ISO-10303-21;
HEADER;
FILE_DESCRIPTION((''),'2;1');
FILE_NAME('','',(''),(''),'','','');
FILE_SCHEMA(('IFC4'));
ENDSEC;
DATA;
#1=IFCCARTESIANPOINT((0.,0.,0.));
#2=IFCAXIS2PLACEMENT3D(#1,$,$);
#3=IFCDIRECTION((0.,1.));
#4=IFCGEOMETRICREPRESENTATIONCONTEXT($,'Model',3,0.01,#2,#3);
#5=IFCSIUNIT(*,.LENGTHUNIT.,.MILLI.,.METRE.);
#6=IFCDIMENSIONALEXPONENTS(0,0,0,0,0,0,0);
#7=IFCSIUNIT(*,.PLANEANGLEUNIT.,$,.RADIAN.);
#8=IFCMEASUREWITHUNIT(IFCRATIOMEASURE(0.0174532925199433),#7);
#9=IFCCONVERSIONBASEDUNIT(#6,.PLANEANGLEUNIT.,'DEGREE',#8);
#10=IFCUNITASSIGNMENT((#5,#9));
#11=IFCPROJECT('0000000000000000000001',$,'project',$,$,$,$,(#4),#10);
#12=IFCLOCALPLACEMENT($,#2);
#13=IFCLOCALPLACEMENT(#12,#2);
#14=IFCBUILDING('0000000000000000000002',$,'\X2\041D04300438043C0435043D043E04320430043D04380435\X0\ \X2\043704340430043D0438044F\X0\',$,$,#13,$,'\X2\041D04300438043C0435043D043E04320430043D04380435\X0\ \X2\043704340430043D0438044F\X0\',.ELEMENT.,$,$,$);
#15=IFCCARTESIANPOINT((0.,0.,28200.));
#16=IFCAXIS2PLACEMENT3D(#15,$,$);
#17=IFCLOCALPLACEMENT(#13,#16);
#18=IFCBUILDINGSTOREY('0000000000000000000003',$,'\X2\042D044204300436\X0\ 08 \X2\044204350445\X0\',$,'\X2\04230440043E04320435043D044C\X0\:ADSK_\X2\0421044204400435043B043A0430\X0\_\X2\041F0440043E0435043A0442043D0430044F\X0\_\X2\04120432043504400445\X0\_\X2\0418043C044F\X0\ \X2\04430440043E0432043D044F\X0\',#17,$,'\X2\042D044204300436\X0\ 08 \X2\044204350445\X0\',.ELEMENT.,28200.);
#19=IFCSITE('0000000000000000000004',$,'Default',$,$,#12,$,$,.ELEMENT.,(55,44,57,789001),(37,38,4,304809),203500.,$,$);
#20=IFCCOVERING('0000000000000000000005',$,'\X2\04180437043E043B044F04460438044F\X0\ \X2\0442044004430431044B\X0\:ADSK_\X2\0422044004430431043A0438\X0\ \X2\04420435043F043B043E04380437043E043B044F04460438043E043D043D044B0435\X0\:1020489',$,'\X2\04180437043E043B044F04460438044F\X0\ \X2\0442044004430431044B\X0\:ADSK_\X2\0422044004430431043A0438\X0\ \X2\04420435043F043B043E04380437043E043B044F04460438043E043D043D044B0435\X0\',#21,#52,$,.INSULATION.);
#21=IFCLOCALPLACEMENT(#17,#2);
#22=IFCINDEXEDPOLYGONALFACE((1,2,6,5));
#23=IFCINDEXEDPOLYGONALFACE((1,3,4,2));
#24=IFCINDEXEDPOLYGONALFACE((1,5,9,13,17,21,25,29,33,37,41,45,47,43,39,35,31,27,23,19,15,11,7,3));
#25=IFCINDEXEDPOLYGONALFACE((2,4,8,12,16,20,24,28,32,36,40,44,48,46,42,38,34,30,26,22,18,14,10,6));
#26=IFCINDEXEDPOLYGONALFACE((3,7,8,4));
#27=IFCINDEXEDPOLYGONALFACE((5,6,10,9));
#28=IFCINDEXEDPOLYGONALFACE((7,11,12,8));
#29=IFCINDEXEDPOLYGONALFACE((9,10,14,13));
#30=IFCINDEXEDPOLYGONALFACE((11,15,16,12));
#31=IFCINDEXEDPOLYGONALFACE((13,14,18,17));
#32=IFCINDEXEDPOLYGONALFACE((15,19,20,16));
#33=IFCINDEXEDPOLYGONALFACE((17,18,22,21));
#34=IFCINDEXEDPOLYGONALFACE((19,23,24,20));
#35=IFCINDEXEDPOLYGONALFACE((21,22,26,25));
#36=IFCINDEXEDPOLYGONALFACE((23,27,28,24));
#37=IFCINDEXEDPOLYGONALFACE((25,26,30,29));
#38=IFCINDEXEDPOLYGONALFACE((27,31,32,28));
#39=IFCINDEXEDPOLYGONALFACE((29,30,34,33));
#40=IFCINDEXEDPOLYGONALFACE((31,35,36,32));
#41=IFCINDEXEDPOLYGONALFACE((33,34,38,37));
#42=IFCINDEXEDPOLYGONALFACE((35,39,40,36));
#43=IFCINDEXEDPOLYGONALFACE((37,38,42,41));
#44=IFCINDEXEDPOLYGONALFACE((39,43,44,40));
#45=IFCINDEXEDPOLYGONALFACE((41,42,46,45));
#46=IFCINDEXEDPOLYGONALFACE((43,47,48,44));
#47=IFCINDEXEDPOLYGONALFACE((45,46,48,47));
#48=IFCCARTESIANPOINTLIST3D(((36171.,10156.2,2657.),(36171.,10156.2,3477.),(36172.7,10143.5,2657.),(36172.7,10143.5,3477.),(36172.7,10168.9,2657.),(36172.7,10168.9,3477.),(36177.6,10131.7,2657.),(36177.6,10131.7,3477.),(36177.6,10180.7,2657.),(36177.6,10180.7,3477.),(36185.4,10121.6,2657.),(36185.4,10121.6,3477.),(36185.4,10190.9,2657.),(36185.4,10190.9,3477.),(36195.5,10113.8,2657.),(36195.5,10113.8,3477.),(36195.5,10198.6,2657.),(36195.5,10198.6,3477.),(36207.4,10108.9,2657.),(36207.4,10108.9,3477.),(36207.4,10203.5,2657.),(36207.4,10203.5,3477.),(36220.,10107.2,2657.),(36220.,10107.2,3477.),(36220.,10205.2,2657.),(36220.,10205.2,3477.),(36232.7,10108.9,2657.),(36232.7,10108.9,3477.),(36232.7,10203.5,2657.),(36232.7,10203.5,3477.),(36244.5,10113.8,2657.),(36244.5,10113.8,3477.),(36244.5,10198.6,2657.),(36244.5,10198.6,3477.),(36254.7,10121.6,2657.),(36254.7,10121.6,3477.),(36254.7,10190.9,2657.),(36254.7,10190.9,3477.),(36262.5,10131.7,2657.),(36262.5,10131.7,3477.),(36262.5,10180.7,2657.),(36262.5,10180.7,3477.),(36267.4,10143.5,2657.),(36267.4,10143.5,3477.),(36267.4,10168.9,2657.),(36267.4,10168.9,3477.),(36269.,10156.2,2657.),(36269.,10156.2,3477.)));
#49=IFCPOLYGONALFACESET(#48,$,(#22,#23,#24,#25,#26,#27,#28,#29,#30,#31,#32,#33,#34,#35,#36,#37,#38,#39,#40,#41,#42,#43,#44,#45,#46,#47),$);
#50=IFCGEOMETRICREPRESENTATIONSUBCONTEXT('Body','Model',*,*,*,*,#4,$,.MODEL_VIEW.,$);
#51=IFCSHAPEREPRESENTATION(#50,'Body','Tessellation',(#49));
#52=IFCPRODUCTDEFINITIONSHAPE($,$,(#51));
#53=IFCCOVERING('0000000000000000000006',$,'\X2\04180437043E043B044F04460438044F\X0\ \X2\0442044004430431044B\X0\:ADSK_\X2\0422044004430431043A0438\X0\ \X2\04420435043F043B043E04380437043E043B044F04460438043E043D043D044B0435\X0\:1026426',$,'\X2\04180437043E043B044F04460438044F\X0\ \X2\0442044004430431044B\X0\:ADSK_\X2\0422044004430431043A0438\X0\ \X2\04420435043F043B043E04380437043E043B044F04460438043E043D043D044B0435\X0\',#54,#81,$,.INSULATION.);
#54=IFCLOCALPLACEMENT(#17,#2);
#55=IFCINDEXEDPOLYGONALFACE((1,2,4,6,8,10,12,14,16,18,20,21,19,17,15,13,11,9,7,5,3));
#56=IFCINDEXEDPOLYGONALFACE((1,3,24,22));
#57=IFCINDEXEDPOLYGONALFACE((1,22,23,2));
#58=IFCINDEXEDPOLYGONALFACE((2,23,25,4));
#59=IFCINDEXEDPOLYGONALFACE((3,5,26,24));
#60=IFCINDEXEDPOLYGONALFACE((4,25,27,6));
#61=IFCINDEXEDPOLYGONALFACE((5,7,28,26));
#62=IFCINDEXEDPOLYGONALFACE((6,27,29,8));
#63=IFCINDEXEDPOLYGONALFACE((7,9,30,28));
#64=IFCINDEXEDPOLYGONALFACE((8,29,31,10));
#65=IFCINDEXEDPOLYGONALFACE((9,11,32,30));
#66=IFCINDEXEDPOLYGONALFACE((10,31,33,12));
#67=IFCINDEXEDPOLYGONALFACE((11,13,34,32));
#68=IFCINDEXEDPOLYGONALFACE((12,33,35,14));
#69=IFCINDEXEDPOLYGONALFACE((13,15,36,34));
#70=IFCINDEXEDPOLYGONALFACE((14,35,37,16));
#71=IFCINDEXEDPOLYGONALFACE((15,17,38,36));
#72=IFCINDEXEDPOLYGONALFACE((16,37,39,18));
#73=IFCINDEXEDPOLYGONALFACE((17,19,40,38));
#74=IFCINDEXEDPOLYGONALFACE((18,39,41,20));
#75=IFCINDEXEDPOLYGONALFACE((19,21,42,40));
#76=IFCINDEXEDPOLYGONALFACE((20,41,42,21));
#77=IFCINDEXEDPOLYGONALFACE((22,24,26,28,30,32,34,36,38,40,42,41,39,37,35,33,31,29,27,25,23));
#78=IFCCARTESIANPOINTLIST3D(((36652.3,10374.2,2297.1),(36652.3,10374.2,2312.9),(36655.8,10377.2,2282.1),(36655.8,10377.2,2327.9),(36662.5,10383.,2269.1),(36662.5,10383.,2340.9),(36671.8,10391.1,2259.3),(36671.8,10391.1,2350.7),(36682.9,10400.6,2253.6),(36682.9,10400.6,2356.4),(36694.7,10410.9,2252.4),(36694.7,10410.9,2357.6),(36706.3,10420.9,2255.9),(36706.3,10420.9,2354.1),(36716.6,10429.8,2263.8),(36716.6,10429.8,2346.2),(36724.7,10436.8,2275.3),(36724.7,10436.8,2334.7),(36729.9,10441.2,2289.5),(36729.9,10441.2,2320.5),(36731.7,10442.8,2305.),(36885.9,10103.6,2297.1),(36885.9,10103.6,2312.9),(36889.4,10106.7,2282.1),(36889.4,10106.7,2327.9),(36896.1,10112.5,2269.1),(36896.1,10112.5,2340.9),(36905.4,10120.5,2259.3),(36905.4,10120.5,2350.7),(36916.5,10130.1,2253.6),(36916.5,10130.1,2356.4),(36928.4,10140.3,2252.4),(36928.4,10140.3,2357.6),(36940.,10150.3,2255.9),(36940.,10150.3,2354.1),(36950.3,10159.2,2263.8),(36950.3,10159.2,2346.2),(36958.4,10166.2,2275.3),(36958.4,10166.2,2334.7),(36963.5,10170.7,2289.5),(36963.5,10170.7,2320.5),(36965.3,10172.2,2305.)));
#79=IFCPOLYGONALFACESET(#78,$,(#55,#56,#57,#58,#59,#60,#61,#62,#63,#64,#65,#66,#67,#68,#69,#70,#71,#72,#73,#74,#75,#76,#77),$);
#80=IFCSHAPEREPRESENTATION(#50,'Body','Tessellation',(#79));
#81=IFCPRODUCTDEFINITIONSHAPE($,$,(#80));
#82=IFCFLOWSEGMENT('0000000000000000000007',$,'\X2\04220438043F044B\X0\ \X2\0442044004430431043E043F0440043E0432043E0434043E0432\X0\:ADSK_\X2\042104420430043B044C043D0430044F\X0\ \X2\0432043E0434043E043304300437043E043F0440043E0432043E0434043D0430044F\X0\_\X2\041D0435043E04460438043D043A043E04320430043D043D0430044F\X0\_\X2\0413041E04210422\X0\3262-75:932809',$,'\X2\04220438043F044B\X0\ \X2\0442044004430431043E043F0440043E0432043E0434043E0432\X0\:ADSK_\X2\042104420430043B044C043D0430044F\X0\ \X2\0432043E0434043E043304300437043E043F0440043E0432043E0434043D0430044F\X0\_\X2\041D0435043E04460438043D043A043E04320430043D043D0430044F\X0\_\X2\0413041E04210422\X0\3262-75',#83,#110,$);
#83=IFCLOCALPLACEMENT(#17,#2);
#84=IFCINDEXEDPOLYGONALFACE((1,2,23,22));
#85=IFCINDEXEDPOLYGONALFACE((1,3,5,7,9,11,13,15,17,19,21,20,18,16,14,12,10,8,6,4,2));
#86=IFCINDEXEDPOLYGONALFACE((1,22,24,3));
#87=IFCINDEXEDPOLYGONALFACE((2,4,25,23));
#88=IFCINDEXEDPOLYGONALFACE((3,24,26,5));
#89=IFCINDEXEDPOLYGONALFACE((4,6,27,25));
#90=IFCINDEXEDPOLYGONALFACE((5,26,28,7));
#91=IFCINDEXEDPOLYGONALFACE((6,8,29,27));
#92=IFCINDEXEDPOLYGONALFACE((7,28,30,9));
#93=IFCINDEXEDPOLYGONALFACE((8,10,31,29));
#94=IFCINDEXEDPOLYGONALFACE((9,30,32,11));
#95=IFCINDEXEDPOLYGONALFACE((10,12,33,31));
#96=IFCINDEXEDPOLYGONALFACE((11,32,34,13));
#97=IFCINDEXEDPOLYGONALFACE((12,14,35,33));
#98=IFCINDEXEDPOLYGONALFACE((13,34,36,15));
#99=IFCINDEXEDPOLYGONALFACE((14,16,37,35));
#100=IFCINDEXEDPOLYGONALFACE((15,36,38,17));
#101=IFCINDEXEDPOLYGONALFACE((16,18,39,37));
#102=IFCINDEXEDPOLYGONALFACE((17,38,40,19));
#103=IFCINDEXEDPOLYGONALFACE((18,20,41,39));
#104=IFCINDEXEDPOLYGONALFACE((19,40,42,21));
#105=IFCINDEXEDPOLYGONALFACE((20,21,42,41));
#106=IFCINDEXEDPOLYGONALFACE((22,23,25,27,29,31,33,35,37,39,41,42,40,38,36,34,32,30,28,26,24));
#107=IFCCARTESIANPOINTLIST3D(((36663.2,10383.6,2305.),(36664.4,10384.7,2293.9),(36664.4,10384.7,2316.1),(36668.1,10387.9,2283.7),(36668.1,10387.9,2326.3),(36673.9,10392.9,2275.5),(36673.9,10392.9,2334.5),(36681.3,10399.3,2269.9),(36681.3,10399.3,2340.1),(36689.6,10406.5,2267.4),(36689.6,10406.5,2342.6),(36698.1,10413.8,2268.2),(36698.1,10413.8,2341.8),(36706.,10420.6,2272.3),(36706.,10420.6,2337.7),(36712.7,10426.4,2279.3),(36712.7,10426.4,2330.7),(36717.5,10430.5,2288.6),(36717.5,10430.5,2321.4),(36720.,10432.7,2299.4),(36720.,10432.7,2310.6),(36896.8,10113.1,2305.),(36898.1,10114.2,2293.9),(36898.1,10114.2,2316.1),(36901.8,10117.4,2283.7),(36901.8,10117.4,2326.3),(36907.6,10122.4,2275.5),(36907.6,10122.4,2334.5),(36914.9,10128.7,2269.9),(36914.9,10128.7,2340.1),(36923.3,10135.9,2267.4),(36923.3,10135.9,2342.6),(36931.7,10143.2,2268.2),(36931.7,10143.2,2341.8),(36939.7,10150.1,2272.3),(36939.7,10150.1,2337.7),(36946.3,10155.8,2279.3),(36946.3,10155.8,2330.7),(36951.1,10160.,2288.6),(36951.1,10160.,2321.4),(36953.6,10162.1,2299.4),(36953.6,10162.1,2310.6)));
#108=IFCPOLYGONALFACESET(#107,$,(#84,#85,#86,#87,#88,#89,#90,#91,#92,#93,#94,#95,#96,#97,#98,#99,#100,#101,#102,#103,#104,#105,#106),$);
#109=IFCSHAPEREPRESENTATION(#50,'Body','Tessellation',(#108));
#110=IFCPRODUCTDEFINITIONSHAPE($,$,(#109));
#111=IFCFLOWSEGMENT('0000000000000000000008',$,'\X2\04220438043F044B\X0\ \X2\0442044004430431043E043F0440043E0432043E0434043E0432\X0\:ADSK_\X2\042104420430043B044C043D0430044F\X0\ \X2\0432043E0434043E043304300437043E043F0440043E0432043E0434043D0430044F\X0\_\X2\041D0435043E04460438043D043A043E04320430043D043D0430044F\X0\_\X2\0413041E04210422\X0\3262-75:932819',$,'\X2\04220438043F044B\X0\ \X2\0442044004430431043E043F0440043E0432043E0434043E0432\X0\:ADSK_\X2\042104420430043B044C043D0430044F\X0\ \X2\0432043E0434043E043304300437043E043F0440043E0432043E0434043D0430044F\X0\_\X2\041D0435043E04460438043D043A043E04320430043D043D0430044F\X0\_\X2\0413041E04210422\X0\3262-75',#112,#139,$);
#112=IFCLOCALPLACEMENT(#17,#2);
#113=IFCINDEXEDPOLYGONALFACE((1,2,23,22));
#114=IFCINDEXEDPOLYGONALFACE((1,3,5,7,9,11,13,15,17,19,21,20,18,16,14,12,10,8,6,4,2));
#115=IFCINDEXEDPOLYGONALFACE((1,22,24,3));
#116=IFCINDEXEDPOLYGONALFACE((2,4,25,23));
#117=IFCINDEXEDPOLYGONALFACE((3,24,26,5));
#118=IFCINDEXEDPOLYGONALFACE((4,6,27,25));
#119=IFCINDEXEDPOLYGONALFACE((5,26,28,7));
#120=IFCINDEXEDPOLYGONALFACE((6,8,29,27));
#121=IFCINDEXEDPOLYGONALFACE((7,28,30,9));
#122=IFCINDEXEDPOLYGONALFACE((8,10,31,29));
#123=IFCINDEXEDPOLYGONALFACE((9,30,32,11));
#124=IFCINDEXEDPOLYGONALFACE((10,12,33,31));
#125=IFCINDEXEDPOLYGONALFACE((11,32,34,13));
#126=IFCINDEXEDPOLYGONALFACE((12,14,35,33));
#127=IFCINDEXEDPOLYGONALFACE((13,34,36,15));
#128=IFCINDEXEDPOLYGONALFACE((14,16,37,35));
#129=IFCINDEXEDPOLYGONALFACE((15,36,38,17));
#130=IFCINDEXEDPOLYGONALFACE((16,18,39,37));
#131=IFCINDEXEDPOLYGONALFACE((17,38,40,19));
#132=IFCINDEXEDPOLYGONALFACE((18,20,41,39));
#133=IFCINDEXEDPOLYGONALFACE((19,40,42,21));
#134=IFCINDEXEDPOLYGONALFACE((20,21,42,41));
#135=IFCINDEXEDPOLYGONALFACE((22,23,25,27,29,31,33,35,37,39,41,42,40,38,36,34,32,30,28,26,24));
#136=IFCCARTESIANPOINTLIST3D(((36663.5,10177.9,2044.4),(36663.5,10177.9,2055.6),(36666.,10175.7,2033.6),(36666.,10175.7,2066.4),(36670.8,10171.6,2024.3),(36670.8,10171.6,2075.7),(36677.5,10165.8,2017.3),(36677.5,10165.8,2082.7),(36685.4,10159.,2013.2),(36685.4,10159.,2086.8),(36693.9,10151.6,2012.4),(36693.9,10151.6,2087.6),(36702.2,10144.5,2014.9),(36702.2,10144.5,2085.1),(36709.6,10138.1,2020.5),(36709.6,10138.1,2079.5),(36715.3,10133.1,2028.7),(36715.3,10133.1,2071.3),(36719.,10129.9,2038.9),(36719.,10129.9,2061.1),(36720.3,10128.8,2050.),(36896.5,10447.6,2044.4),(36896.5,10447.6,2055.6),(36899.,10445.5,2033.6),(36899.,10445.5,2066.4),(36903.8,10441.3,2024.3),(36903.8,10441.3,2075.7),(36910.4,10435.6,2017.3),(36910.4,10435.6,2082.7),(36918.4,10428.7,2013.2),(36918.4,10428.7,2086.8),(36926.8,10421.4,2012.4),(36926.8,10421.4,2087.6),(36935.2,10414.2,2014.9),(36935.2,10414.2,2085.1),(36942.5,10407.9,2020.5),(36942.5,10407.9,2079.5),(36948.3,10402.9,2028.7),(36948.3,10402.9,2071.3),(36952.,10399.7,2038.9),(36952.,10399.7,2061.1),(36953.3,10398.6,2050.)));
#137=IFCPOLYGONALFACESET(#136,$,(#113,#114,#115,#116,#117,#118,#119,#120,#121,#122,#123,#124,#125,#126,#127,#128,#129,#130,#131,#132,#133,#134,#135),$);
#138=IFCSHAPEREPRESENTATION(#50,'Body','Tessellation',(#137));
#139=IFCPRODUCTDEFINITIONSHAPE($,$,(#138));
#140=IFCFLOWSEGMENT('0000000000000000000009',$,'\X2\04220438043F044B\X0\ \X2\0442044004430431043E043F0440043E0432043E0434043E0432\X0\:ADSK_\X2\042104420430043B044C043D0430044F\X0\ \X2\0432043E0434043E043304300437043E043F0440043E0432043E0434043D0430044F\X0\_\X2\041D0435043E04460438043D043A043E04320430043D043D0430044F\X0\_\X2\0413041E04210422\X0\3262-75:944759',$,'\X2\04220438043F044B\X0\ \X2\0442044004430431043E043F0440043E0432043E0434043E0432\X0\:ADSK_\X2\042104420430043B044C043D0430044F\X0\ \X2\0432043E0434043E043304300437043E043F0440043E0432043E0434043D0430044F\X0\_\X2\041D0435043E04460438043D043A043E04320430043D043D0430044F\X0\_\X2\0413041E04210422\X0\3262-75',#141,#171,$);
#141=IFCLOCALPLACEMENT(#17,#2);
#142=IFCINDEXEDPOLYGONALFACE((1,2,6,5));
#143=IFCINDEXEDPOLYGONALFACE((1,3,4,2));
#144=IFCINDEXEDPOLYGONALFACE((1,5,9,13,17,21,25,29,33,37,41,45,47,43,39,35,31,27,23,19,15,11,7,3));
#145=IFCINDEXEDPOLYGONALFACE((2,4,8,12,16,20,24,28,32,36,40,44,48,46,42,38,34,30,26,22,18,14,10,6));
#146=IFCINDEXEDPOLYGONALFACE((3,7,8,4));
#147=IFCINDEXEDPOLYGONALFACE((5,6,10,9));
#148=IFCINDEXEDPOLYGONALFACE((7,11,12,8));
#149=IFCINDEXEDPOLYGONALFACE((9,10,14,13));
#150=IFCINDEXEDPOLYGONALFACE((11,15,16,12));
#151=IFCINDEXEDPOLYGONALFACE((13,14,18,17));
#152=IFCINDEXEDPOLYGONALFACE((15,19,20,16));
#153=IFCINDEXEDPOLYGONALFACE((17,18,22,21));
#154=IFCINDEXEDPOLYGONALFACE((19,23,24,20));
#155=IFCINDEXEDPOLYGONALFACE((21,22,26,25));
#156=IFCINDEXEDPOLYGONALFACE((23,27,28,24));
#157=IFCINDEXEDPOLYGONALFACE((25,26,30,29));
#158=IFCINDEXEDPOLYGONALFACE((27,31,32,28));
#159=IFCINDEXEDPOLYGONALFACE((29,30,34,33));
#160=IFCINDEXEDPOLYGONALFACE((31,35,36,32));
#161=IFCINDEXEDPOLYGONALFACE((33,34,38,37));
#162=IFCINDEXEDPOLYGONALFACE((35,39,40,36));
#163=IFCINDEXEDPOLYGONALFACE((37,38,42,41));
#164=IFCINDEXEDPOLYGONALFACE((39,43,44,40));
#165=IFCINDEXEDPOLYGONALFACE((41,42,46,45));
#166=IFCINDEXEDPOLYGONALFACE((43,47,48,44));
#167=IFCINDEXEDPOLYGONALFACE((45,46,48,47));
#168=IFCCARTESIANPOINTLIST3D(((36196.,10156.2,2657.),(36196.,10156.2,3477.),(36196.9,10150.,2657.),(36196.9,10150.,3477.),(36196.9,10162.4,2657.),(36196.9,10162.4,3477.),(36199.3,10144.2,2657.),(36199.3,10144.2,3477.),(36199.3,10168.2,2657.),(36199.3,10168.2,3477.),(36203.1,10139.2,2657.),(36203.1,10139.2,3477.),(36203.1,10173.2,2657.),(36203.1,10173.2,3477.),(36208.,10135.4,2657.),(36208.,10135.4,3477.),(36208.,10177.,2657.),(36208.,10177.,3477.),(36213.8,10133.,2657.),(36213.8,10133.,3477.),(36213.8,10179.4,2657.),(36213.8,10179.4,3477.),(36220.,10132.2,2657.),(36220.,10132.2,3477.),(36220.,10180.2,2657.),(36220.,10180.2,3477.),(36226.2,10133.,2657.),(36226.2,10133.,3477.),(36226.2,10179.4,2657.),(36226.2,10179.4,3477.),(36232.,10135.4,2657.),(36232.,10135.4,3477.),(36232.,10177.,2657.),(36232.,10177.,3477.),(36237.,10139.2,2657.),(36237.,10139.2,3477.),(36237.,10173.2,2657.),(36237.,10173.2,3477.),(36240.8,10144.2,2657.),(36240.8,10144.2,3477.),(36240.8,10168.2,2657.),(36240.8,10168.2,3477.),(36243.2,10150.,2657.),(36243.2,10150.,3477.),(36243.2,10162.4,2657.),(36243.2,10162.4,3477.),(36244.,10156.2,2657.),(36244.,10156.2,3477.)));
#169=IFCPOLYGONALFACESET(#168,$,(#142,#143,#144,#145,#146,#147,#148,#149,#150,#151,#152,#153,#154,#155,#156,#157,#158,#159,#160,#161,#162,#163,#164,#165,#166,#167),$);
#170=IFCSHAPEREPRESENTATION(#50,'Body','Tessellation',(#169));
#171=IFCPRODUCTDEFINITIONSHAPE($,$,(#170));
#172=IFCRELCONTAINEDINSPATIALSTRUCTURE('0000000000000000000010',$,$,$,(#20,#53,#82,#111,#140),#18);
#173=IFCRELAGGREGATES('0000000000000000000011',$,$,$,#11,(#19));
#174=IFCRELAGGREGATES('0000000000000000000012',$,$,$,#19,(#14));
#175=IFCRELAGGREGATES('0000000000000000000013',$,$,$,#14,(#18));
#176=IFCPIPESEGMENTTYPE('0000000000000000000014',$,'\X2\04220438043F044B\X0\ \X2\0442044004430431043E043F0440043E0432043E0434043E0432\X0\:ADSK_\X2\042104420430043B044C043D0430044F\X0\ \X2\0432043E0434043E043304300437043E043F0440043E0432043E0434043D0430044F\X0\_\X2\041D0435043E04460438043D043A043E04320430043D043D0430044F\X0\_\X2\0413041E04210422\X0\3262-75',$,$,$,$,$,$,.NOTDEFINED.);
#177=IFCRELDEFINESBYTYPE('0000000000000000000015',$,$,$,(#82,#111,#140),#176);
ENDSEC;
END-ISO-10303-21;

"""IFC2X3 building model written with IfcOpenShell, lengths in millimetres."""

from ifc_helpers import new_model, entity, si_unit, converted_unit, direction, frame, origin, origin_2d_with_axis, place, context, subcontext, project, spatial, polyline, circle, outline, extrude, type_object, element, save


model = new_model("IFC2X3")

# Units and contexts
model_context = context("Model", 3, precision=0.01, world=origin(), true_north=direction((0.0, 1.0)))
body_context = subcontext(model_context, "Body", "Model", "MODEL_VIEW")
ifc_project = project(units=[si_unit("LENGTHUNIT", "METRE", prefix="MILLI"), converted_unit("PLANEANGLEUNIT", "DEGREE", entity("IfcRatioMeasure", 0.0174532925199433), si_unit("PLANEANGLEUNIT", "RADIAN"), dimensions=[0, 0, 0, 0, 0, 0, 0])], contexts=[model_context])

# Site, building, storey
site_placement = place(None, origin())
site = spatial("IfcSite", under=ifc_project, at=site_placement, Name="Default", CompositionType="ELEMENT", RefLatitude=(55, 44, 57, 789001), RefLongitude=(37, 38, 4, 304809), RefElevation=203500.0)
building_placement = place(site_placement, origin())
building = spatial("IfcBuilding", under=site, at=building_placement, Name="Наименование здания", LongName="Наименование здания", CompositionType="ELEMENT")
storey_placement = place(building_placement, frame((0.0, 0.0, 28200.0)))
storey = spatial("IfcBuildingStorey", under=building, at=storey_placement, Name="Этаж 08 тех", ObjectType="Уровень:ADSK_Стрелка_Проектная_Вверх_Имя уровня", LongName="Этаж 08 тех", CompositionType="ELEMENT", Elevation=28200.0)

# Coverings
covering_1_placement = place(storey_placement, frame((36169.4, 10105.6, 2657.0)))
element("IfcCovering", 1, at=covering_1_placement, inside=storey, Name="Изоляция трубы:ADSK_Трубки теплоизоляционные:1020489", ObjectType="Изоляция трубы:ADSK_Трубки теплоизоляционные", PredefinedType="INSULATION", context=body_context, shape_type="SweptSolid", body=[
    extrude(outline(polyline([(-6.4, -48.6), (6.4, -48.6), (18.8, -45.3), (29.8, -38.9), (38.9, -29.8), (45.3, -18.8), (48.6, -6.4), (48.6, 6.4), (45.3, 18.8), (38.9, 29.8), (29.8, 38.9), (18.8, 45.3), (6.4, 48.6), (-6.4, 48.6), (-18.8, 45.3), (-29.8, 38.9), (-38.9, 29.8), (-45.3, 18.8), (-48.6, 6.4), (-48.6, -6.4), (-45.3, -18.8), (-38.9, -29.8), (-29.8, -38.9), (-18.8, -45.3), (-6.4, -48.6)])), frame((50.6, 50.6, 0.0), z_axis=(0.0, 0.0, 1.0), x_axis=(0.991445, 0.130526, 0.0)), (0.0, 0.0, 1.0), 820.0),
])
covering_2_placement = place(storey_placement, frame((36650.2, 10101.7, 2250.7)))
element("IfcCovering", 2, at=covering_2_placement, inside=storey, Name="Изоляция трубы:ADSK_Трубки теплоизоляционные:1026426", ObjectType="Изоляция трубы:ADSK_Трубки теплоизоляционные", PredefinedType="INSULATION", context=body_context, shape_type="SweptSolid", body=[
    extrude(circle(Radius=52.8, at=origin_2d_with_axis()), frame((41.5, 306.6, 54.4), z_axis=(0.653591, -0.756848, 0.0), x_axis=(0.756848, 0.653591, 0.0)), (0.0, 0.0, 1.0), 357.5),
])

# Flow segments
pipe_segment_type = type_object("IfcPipeSegmentType", Name="Типы трубопроводов:ADSK_Стальная водогазопроводная_Неоцинкованная_ГОСТ3262-75", PredefinedType="NOTDEFINED")
flow_segment_1_placement = place(storey_placement, frame((36661.6, 10111.5, 2265.7)))
element("IfcFlowSegment", 3, at=flow_segment_1_placement, inside=storey, type_object=pipe_segment_type, Name="Типы трубопроводов:ADSK_Стальная водогазопроводная_Неоцинкованная_ГОСТ3262-75:932809", ObjectType="Типы трубопроводов:ADSK_Стальная водогазопроводная_Неоцинкованная_ГОСТ3262-75", context=body_context, shape_type="SweptSolid", body=[
    extrude(circle(Radius=37.8, at=origin_2d_with_axis()), frame((30.2, 296.8, 39.4), z_axis=(0.653591, -0.756848, 0.0), x_axis=(-0.756848, -0.653591, 0.0)), (0.0, 0.0, 1.0), 357.5),
])
flow_segment_2_placement = place(storey_placement, frame((36661.6, 10127.2, 2010.7)))
element("IfcFlowSegment", 4, at=flow_segment_2_placement, inside=storey, type_object=pipe_segment_type, Name="Типы трубопроводов:ADSK_Стальная водогазопроводная_Неоцинкованная_ГОСТ3262-75:932819", ObjectType="Типы трубопроводов:ADSK_Стальная водогазопроводная_Неоцинкованная_ГОСТ3262-75", context=body_context, shape_type="SweptSolid", body=[
    extrude(circle(Radius=37.8, at=origin_2d_with_axis()), frame((30.2, 26.3, 39.4), z_axis=(0.653617, 0.756825, 0.0), x_axis=(0.756825, -0.653617, 0.0)), (0.0, 0.0, 1.0), 356.4),
])
flow_segment_3_placement = place(storey_placement, frame((36194.4, 10130.6, 2657.0)))
element("IfcFlowSegment", 5, at=flow_segment_3_placement, inside=storey, type_object=pipe_segment_type, Name="Типы трубопроводов:ADSK_Стальная водогазопроводная_Неоцинкованная_ГОСТ3262-75:944759", ObjectType="Типы трубопроводов:ADSK_Стальная водогазопроводная_Неоцинкованная_ГОСТ3262-75", context=body_context, shape_type="SweptSolid", body=[
    extrude(outline(polyline([(-3.1, -23.8), (3.1, -23.8), (9.2, -22.2), (14.6, -19.0), (19.0, -14.6), (22.2, -9.2), (23.8, -3.1), (23.8, 3.1), (22.2, 9.2), (19.0, 14.6), (14.6, 19.0), (9.2, 22.2), (3.1, 23.8), (-3.1, 23.8), (-9.2, 22.2), (-14.6, 19.0), (-19.0, 14.6), (-22.2, 9.2), (-23.8, 3.1), (-23.8, -3.1), (-22.2, -9.2), (-19.0, -14.6), (-14.6, -19.0), (-9.2, -22.2), (-3.1, -23.8)])), frame((25.6, 25.6, 0.0), z_axis=(0.0, 0.0, 1.0), x_axis=(-0.130526, 0.991445, 0.0)), (0.0, 0.0, 1.0), 820.0),
])

save(model, "model.ifc")
